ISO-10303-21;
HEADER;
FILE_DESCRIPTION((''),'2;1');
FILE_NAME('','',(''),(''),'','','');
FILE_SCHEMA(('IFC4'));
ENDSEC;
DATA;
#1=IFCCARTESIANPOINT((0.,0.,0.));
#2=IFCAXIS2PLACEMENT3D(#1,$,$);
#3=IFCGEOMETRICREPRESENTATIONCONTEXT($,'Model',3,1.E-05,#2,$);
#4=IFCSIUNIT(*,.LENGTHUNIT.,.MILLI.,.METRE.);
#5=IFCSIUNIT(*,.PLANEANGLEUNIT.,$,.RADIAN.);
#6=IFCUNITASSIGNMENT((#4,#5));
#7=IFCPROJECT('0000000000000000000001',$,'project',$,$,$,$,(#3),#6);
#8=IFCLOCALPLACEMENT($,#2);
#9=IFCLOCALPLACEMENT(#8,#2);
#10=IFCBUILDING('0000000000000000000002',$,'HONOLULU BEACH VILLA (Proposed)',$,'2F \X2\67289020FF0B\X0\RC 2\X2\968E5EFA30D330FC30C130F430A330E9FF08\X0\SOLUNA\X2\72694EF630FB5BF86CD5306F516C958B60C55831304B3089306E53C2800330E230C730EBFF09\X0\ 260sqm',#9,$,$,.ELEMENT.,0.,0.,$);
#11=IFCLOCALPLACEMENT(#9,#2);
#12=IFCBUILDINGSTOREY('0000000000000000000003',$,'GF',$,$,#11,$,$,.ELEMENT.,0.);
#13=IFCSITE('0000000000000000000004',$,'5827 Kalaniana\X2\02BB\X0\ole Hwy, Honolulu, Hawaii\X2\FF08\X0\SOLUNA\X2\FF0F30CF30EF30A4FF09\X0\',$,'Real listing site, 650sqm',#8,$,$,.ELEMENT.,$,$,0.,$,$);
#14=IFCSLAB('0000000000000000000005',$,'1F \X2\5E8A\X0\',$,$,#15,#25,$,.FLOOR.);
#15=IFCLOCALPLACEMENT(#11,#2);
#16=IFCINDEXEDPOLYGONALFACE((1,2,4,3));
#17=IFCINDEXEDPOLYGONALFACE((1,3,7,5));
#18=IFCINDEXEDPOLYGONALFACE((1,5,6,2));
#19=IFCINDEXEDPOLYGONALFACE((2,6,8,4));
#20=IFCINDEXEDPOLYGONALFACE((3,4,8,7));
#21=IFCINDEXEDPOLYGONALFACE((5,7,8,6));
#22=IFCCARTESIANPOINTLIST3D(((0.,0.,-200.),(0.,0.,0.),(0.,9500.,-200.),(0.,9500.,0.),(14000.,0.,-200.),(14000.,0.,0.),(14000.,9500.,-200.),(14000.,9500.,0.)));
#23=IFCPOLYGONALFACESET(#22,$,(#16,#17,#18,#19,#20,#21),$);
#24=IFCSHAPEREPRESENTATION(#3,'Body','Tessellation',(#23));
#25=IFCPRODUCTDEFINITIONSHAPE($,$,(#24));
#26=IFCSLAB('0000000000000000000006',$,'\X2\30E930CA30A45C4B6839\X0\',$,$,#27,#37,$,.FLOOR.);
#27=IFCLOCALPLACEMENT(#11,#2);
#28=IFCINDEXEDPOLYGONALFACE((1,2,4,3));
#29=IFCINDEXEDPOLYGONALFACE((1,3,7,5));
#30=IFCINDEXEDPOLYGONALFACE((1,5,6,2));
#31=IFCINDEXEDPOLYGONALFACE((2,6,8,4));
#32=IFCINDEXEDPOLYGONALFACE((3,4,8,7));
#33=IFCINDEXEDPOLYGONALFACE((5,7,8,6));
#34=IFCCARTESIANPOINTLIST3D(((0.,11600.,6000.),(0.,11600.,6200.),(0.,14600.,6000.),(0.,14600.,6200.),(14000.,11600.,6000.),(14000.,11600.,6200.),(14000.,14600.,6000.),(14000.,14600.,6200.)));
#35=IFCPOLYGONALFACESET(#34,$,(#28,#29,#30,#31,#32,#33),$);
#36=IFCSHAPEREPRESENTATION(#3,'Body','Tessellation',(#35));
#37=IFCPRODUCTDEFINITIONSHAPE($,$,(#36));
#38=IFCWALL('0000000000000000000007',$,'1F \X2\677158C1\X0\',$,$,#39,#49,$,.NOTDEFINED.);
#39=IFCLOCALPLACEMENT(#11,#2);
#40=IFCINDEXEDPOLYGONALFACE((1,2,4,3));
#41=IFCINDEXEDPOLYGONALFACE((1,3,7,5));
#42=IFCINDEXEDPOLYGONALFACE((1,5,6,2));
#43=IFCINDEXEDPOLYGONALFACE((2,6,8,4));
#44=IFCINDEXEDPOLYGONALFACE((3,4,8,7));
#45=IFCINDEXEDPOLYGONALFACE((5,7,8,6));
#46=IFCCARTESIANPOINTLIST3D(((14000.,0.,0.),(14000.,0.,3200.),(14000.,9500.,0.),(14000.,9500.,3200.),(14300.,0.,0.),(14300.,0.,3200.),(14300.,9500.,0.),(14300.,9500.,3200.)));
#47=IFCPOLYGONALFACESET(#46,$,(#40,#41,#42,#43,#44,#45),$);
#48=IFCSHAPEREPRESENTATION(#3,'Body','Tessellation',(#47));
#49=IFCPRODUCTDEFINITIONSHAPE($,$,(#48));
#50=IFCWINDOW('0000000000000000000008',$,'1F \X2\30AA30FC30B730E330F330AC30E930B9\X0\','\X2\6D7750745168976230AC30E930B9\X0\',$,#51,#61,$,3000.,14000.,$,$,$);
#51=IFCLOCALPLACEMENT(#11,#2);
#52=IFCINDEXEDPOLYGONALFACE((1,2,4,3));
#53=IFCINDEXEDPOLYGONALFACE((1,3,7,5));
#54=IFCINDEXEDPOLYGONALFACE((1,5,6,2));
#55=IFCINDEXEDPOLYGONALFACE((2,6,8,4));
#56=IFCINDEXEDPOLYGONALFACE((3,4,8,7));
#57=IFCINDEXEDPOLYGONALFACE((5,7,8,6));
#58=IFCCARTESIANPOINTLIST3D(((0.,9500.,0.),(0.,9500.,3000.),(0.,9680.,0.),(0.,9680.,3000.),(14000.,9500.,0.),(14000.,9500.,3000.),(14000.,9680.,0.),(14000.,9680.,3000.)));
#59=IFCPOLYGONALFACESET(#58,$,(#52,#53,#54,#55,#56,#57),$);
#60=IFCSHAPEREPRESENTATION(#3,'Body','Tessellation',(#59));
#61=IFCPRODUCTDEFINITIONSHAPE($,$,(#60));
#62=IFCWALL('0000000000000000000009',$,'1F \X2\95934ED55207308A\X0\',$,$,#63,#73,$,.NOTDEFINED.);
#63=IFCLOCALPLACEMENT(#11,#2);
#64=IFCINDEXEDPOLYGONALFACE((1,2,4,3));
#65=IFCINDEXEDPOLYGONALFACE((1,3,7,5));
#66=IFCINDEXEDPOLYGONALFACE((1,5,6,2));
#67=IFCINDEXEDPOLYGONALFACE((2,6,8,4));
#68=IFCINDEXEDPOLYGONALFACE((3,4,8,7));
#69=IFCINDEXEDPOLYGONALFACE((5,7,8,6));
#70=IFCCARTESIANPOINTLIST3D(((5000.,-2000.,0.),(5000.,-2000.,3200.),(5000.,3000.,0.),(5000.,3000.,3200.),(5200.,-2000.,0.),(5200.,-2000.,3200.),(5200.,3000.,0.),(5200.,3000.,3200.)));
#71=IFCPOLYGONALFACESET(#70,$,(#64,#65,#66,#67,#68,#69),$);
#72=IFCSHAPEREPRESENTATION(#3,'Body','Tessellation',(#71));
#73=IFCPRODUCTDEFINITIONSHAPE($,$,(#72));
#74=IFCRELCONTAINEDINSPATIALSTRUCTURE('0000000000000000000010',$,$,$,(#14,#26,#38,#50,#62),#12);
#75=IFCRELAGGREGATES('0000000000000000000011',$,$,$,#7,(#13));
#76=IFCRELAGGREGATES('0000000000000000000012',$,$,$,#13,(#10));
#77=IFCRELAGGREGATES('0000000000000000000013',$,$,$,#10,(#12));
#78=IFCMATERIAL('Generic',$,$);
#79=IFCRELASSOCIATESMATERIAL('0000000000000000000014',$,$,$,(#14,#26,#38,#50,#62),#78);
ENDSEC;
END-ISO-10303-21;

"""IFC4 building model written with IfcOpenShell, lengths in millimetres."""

from ifc_helpers import new_model, si_unit, frame, frame_2d, origin, place, context, project, spatial, rectangle, extrude, material, element, fill, save


model = new_model("IFC4")

# Units and contexts
model_context = context("Model", 3, precision=1e-05, world=origin())
ifc_project = project(units=[si_unit("LENGTHUNIT", "METRE", prefix="MILLI"), si_unit("PLANEANGLEUNIT", "RADIAN")], contexts=[model_context])

# Site, building, storey
site_placement = place(None, origin())
site = spatial("IfcSite", under=ifc_project, at=site_placement, Name="5827 Kalanianaʻole Hwy, Honolulu, Hawaii（SOLUNA／ハワイ）", ObjectType="Real listing site, 650sqm", CompositionType="ELEMENT", RefElevation=0.0)
building_placement = place(site_placement, origin())
building = spatial("IfcBuilding", under=site, at=building_placement, Name="HONOLULU BEACH VILLA (Proposed)", ObjectType="2F 木造＋RC 2階建ビーチヴィラ（SOLUNA物件・寸法は公開情報からの参考モデル） 260sqm", CompositionType="ELEMENT", ElevationOfRefHeight=0.0, ElevationOfTerrain=0.0)
storey_placement = place(building_placement, origin())
storey = spatial("IfcBuildingStorey", under=building, at=storey_placement, Name="GF", CompositionType="ELEMENT", Elevation=0.0)

# Shared definitions
ifc_material_1 = material(Name="Generic")

# Slabs
slab_1_placement = place(storey_placement, frame((0.0, 0.0, -100.0)))
element("IfcSlab", 1, at=slab_1_placement, inside=storey, material=ifc_material_1, Name="1F 床", PredefinedType="FLOOR", context=model_context, shape_type="SweptSolid", body=[
    extrude(rectangle(XDim=14000.0, YDim=9500.0, at=frame_2d((7000.0, 4750.0))), frame((0.0, 0.0, -100.0)), (0.0, 0.0, 1.0), 200.0),
])
slab_2_placement = place(storey_placement, frame((0.0, 5800.0, 3000.0)))
element("IfcSlab", 2, at=slab_2_placement, inside=storey, material=ifc_material_1, Name="ラナイ屋根", PredefinedType="FLOOR", context=model_context, shape_type="SweptSolid", body=[
    extrude(rectangle(XDim=14000.0, YDim=3000.0, at=frame_2d((7000.0, 1500.0))), frame((0.0, 5800.0, 3000.0)), (0.0, 0.0, 1.0), 200.0),
])

# Wall, opening, window
wall_1_placement = place(storey_placement, frame((7000.0, 0.0, 0.0)))
wall_1 = element("IfcWall", 3, at=wall_1_placement, inside=storey, material=ifc_material_1, Name="1F 東壁", PredefinedType="NOTDEFINED", context=model_context, shape_type="SweptSolid", body=[
    extrude(rectangle(XDim=300.0, YDim=9500.0, at=frame_2d((150.0, 4750.0))), frame((7000.0, 0.0, 0.0)), (0.0, 0.0, 1.0), 3200.0),
])
opening_1_placement = place(storey_placement, frame((0.0, 4750.0, 0.0)))
opening_1 = element("IfcOpeningElement", 4, at=opening_1_placement, cuts=wall_1, PredefinedType="NOTDEFINED", context=model_context, shape_type="SweptSolid", body=[
    extrude(rectangle(XDim=14000.0, YDim=180.0, at=frame_2d((7000.0, 90.0))), frame((0.0, 4750.0, 0.0)), (0.0, 0.0, 1.0), 3000.0),
])
window_1_placement = place(storey_placement, frame((0.0, 4750.0, 0.0)))
window_1 = element("IfcWindow", 5, at=window_1_placement, inside=storey, material=ifc_material_1, Name="1F オーシャンガラス", Description="海側全面ガラス", OverallHeight=3000.0, OverallWidth=14000.0, context=model_context, shape_type="SweptSolid", body=[
    extrude(rectangle(XDim=14000.0, YDim=180.0, at=frame_2d((7000.0, 90.0))), frame((0.0, 4750.0, 0.0)), (0.0, 0.0, 1.0), 3000.0),
])
fill(opening_1, window_1)

# Wall
wall_2_placement = place(storey_placement, frame((2500.0, -1000.0, 0.0)))
element("IfcWall", 6, at=wall_2_placement, inside=storey, material=ifc_material_1, Name="1F 間仕切り", PredefinedType="NOTDEFINED", context=model_context, shape_type="SweptSolid", body=[
    extrude(rectangle(XDim=200.0, YDim=5000.0, at=frame_2d((100.0, 2500.0))), frame((2500.0, -1000.0, 0.0)), (0.0, 0.0, 1.0), 3200.0),
])

save(model, "model.ifc")
